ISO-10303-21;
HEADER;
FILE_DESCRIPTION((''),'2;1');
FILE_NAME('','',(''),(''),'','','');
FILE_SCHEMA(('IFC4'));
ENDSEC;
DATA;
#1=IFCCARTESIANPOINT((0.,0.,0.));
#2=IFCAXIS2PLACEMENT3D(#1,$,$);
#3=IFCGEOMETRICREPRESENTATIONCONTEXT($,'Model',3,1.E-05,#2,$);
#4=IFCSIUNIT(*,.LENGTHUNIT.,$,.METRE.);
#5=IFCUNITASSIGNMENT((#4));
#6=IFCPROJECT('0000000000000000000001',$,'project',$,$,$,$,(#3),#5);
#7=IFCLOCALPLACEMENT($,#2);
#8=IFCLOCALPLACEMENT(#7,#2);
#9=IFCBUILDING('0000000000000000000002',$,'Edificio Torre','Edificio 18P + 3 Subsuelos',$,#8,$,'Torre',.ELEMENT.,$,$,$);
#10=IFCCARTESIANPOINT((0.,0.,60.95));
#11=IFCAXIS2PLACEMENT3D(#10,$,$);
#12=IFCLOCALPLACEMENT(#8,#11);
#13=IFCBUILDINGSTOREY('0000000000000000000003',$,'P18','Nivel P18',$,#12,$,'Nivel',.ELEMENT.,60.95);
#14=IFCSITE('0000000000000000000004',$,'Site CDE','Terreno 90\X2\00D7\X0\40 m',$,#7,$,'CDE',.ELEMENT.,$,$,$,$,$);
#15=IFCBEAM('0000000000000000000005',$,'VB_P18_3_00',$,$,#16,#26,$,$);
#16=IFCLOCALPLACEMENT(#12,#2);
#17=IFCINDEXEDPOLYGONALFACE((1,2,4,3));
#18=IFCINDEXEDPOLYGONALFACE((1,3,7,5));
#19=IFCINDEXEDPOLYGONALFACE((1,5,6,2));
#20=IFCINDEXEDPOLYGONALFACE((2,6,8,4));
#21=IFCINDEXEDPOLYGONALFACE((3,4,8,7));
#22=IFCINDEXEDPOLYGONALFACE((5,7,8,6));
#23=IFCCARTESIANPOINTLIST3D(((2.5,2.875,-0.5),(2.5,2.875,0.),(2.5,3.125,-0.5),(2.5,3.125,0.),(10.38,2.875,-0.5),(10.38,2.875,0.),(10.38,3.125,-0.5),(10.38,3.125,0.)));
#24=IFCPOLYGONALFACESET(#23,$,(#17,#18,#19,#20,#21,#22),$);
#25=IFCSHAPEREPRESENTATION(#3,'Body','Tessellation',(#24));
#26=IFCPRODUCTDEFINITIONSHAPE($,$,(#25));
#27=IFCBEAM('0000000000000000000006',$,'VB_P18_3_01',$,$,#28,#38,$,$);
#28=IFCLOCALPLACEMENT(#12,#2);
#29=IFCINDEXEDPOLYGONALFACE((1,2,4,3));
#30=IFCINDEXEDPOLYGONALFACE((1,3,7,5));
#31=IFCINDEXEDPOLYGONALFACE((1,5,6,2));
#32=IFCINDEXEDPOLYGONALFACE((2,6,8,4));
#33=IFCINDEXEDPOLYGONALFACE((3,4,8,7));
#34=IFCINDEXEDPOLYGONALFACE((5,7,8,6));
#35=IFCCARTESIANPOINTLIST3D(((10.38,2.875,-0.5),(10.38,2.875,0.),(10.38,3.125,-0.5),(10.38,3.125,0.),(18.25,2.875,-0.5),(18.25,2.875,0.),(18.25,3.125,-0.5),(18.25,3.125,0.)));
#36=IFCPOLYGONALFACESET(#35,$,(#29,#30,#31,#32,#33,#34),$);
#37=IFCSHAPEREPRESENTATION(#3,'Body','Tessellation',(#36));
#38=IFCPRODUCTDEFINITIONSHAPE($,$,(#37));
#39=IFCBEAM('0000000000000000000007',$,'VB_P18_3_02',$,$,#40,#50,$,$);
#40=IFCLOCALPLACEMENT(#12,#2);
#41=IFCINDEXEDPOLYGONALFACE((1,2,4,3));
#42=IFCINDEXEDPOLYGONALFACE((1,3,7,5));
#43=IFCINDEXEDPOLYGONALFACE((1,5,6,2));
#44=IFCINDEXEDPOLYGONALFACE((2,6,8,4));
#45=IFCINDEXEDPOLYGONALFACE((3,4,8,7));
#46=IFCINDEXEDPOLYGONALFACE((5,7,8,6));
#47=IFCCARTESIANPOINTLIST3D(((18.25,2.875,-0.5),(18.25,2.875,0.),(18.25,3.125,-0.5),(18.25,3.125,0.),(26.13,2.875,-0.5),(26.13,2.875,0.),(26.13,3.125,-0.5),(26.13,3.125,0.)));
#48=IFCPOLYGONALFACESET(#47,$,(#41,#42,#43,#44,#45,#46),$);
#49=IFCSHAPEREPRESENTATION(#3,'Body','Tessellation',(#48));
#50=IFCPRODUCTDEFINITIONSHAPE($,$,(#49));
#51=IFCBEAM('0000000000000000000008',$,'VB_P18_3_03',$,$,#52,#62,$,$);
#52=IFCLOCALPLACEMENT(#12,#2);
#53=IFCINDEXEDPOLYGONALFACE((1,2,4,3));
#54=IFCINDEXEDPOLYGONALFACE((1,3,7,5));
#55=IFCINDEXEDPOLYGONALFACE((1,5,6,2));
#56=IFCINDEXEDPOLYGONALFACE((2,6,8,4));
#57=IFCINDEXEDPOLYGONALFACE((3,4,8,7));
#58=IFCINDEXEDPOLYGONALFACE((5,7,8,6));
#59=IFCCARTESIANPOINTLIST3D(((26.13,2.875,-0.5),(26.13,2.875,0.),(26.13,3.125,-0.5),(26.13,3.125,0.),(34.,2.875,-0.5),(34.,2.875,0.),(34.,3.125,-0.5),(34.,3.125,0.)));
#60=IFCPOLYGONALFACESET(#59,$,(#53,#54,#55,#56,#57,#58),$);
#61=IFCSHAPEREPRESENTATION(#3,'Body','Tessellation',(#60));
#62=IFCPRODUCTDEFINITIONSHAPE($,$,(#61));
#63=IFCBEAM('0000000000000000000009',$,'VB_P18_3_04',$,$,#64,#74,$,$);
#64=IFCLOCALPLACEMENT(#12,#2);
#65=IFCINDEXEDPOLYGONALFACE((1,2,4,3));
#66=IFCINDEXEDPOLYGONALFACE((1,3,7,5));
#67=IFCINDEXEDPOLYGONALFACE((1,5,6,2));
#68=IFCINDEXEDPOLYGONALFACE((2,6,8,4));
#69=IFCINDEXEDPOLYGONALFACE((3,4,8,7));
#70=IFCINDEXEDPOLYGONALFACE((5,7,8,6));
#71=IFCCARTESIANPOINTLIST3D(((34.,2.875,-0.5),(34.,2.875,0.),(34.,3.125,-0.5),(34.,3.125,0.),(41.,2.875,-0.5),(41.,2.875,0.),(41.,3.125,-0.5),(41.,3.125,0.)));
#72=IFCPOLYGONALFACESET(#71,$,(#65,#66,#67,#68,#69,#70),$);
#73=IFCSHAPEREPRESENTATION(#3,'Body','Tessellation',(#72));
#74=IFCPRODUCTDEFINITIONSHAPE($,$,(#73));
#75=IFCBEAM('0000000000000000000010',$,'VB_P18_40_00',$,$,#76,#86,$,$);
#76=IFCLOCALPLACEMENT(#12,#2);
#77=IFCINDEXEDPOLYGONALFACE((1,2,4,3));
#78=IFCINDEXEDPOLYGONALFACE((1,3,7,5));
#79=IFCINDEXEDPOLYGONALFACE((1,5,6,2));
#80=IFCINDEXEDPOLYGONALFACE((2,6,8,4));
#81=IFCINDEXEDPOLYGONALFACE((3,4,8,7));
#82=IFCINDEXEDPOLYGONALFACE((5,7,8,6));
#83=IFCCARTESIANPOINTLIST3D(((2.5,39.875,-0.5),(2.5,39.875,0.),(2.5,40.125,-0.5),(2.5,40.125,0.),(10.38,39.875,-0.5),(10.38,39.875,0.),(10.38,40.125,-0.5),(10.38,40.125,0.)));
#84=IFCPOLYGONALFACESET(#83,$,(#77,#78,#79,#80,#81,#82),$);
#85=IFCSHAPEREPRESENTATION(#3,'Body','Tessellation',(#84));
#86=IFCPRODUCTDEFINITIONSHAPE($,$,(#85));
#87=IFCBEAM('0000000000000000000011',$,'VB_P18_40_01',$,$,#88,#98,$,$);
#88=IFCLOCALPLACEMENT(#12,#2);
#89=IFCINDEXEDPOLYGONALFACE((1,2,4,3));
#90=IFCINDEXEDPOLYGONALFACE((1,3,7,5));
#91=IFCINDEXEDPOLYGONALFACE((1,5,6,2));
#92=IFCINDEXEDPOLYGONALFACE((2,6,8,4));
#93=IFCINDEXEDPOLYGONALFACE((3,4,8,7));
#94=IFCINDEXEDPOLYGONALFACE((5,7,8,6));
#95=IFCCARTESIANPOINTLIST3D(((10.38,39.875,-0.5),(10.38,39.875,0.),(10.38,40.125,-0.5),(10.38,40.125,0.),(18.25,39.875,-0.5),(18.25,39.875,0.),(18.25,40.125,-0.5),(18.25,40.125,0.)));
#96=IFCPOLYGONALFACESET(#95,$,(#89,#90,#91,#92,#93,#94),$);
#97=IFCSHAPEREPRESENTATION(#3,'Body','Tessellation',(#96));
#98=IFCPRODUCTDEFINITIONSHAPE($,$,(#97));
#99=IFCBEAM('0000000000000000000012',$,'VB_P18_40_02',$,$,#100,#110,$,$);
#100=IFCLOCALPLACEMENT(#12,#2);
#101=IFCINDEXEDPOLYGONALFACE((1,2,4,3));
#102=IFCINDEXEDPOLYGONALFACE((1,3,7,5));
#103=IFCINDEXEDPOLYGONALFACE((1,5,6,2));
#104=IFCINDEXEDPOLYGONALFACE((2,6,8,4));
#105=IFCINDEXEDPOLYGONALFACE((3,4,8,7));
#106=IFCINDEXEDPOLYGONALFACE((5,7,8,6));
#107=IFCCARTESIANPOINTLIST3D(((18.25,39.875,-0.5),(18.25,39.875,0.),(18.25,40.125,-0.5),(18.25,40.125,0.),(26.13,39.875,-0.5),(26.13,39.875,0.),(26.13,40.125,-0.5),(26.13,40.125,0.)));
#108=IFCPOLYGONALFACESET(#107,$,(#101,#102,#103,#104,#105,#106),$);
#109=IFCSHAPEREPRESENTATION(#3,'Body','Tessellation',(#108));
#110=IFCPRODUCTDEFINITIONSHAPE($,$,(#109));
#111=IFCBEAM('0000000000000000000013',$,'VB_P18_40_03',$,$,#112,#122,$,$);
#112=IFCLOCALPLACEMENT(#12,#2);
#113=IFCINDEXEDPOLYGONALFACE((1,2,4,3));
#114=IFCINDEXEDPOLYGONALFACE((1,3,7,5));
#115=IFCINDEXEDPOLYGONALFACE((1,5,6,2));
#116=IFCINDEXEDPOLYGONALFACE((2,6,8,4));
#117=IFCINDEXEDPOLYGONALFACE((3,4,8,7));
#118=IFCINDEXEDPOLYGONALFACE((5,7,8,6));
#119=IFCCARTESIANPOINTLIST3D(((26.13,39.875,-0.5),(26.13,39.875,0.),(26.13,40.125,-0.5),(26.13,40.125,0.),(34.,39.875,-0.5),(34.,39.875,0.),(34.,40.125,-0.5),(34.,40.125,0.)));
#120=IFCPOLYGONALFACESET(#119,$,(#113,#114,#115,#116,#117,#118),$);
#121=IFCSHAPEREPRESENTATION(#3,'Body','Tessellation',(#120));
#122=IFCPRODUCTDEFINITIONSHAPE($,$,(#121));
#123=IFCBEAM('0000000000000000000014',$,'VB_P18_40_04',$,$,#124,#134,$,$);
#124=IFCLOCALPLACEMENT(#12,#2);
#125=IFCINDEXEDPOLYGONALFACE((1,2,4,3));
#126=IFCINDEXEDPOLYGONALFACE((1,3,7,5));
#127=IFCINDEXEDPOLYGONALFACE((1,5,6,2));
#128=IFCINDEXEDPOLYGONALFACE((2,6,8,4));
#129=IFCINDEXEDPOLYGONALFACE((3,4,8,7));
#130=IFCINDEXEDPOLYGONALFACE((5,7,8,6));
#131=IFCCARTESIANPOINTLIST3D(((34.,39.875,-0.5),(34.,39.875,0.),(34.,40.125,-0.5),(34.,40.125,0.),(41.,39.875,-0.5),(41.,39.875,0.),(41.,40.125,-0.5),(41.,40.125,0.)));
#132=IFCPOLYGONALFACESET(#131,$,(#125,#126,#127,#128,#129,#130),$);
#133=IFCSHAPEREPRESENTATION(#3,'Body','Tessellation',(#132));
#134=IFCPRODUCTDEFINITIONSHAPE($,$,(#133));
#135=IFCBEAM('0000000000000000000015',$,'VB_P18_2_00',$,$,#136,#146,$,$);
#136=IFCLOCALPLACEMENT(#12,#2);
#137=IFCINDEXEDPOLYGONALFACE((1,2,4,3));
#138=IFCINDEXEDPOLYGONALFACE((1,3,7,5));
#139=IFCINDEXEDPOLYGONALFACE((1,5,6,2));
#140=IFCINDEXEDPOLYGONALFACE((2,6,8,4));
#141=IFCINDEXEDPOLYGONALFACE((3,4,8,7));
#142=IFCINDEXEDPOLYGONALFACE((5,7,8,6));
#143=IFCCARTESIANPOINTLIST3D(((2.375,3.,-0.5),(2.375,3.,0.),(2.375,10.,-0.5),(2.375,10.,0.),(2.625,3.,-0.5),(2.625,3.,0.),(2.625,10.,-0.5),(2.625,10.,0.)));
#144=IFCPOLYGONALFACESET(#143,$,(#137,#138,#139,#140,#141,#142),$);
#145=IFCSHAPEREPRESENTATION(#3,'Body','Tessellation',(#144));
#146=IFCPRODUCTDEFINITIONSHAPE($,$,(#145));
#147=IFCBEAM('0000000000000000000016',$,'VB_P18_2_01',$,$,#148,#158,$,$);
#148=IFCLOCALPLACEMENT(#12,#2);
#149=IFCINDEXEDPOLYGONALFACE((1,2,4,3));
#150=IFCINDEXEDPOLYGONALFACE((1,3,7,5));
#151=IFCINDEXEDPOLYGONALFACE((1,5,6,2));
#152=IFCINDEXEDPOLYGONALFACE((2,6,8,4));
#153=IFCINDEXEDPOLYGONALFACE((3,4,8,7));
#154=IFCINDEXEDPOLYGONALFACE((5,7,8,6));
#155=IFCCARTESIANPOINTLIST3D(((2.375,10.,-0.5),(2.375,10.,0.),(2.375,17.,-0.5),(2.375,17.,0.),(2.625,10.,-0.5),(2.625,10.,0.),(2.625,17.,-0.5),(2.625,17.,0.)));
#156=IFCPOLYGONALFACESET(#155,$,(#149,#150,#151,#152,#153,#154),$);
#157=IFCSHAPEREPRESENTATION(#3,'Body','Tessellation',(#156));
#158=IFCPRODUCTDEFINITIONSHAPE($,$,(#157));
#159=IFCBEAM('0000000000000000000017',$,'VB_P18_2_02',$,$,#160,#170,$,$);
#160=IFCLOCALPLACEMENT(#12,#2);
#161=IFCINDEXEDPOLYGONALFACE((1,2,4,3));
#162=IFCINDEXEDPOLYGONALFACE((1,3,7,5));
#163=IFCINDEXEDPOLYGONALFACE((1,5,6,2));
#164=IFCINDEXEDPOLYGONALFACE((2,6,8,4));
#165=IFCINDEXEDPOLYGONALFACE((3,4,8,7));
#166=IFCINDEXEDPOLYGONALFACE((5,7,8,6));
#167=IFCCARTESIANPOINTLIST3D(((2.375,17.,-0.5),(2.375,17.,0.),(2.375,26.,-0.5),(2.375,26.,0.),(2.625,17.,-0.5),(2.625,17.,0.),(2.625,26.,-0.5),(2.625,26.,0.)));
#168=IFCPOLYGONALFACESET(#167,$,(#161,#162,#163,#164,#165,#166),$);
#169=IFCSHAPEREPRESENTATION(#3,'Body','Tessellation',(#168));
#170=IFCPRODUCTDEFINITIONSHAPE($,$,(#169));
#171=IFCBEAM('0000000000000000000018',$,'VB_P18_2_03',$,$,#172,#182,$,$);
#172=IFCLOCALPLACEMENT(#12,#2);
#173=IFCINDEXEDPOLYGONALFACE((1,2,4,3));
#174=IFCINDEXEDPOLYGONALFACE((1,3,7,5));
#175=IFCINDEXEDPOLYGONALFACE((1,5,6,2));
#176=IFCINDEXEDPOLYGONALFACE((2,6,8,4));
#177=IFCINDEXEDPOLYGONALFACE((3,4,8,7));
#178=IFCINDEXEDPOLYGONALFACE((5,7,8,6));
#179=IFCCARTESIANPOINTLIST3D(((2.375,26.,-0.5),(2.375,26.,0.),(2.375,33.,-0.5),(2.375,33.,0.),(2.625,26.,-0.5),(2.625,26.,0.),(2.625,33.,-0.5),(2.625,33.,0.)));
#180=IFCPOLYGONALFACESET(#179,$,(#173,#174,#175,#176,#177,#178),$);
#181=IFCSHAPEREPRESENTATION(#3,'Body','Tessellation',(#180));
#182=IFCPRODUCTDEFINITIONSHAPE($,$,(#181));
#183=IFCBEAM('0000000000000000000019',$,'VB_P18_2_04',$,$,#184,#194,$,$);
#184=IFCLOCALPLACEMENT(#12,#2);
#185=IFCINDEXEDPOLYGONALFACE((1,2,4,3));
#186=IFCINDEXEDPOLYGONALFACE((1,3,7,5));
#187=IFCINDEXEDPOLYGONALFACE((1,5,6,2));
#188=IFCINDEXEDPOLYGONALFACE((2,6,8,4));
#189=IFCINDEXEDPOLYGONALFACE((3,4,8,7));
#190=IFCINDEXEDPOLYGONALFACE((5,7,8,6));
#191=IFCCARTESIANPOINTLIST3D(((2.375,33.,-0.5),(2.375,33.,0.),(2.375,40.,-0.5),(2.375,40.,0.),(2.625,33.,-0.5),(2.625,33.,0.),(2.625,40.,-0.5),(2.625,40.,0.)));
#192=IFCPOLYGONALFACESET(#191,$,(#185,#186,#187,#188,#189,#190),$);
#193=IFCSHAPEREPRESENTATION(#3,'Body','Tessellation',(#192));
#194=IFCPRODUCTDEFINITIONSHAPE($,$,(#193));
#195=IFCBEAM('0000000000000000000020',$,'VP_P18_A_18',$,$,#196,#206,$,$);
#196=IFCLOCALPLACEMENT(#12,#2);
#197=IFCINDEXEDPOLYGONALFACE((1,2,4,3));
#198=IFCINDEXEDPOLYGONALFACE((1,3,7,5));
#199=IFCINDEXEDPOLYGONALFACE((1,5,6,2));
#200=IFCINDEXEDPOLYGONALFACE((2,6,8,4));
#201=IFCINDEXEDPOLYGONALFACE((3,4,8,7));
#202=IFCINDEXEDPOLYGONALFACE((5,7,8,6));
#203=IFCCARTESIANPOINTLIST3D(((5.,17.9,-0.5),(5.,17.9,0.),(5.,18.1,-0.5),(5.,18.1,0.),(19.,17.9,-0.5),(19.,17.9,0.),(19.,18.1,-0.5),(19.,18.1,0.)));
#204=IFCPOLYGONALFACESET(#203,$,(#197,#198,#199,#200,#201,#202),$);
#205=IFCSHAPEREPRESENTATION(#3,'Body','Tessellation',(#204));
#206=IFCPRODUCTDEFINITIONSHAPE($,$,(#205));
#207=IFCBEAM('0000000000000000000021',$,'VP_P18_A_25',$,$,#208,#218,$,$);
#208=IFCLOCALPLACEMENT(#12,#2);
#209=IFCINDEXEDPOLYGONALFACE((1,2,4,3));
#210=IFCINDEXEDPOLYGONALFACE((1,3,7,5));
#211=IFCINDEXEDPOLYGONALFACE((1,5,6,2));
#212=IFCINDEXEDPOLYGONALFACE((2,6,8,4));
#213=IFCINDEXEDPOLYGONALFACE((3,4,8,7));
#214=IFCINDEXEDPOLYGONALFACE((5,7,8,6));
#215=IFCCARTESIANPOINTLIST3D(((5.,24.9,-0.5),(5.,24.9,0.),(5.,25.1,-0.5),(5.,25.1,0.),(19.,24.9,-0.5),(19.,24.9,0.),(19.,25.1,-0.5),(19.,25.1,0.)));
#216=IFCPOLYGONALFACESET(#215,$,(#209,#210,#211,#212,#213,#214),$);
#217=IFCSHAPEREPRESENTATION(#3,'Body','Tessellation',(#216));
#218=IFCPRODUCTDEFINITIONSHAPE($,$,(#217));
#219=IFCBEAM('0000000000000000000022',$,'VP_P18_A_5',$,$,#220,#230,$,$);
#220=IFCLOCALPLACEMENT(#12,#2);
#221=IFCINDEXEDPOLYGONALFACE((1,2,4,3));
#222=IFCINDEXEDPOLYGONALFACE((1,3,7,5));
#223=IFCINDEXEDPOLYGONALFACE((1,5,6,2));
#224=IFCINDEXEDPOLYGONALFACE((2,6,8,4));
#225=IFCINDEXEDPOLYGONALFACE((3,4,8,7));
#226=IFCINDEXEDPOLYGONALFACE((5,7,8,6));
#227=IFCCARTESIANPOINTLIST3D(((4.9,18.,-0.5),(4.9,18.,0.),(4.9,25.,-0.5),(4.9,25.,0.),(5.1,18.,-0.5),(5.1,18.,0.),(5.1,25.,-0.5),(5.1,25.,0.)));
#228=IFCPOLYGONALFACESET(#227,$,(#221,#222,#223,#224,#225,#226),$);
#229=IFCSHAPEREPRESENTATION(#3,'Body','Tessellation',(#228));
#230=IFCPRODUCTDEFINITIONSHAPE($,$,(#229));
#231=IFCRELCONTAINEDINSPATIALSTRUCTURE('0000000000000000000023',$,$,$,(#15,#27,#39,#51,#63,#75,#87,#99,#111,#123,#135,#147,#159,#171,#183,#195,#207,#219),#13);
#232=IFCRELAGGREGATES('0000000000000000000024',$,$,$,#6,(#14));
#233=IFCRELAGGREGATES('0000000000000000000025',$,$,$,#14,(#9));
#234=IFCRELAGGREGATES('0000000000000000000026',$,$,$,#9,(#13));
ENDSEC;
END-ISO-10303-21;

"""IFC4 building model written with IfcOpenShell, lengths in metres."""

from ifc_helpers import new_model, si_unit, frame, origin, origin_2d, place, context, project, spatial, rectangle, extrude, element, save


model = new_model("IFC4")

# Units and contexts
model_context = context("Model", 3, precision=1e-05, world=origin())
ifc_project = project(units=[si_unit("LENGTHUNIT", "METRE")], contexts=[model_context])

# Site, building, storey
site_placement = place(None, origin())
site = spatial("IfcSite", under=ifc_project, at=site_placement, Name="Site CDE", Description="Terreno 90×40 m", LongName="CDE", CompositionType="ELEMENT")
building_placement = place(site_placement, origin())
building = spatial("IfcBuilding", under=site, at=building_placement, Name="Edificio Torre", Description="Edificio 18P + 3 Subsuelos", LongName="Torre", CompositionType="ELEMENT")
storey_placement = place(building_placement, frame((0.0, 0.0, 60.95)))
storey = spatial("IfcBuildingStorey", under=building, at=storey_placement, Name="P18", Description="Nivel P18", LongName="Nivel", CompositionType="ELEMENT", Elevation=60.95)

# Beams
beam_1_placement = place(storey_placement, frame((6.44, 3.0, -0.5)))
element("IfcBeam", 1, at=beam_1_placement, inside=storey, Name="VB_P18_3_00", context=model_context, shape_type="SweptSolid", body=[
    extrude(rectangle(XDim=7.88, YDim=0.25, at=origin_2d()), origin(), (0.0, 0.0, 1.0), 0.5),
])
beam_2_placement = place(storey_placement, frame((14.315, 3.0, -0.5)))
element("IfcBeam", 2, at=beam_2_placement, inside=storey, Name="VB_P18_3_01", context=model_context, shape_type="SweptSolid", body=[
    extrude(rectangle(XDim=7.87, YDim=0.25, at=origin_2d()), origin(), (0.0, 0.0, 1.0), 0.5),
])
beam_3_placement = place(storey_placement, frame((22.19, 3.0, -0.5)))
element("IfcBeam", 3, at=beam_3_placement, inside=storey, Name="VB_P18_3_02", context=model_context, shape_type="SweptSolid", body=[
    extrude(rectangle(XDim=7.88, YDim=0.25, at=origin_2d()), origin(), (0.0, 0.0, 1.0), 0.5),
])
beam_4_placement = place(storey_placement, frame((30.065, 3.0, -0.5)))
element("IfcBeam", 4, at=beam_4_placement, inside=storey, Name="VB_P18_3_03", context=model_context, shape_type="SweptSolid", body=[
    extrude(rectangle(XDim=7.87, YDim=0.25, at=origin_2d()), origin(), (0.0, 0.0, 1.0), 0.5),
])
beam_5_placement = place(storey_placement, frame((37.5, 3.0, -0.5)))
element("IfcBeam", 5, at=beam_5_placement, inside=storey, Name="VB_P18_3_04", context=model_context, shape_type="SweptSolid", body=[
    extrude(rectangle(XDim=7.0, YDim=0.25, at=origin_2d()), origin(), (0.0, 0.0, 1.0), 0.5),
])
beam_6_placement = place(storey_placement, frame((6.44, 40.0, -0.5)))
element("IfcBeam", 6, at=beam_6_placement, inside=storey, Name="VB_P18_40_00", context=model_context, shape_type="SweptSolid", body=[
    extrude(rectangle(XDim=7.88, YDim=0.25, at=origin_2d()), origin(), (0.0, 0.0, 1.0), 0.5),
])
beam_7_placement = place(storey_placement, frame((14.315, 40.0, -0.5)))
element("IfcBeam", 7, at=beam_7_placement, inside=storey, Name="VB_P18_40_01", context=model_context, shape_type="SweptSolid", body=[
    extrude(rectangle(XDim=7.87, YDim=0.25, at=origin_2d()), origin(), (0.0, 0.0, 1.0), 0.5),
])
beam_8_placement = place(storey_placement, frame((22.19, 40.0, -0.5)))
element("IfcBeam", 8, at=beam_8_placement, inside=storey, Name="VB_P18_40_02", context=model_context, shape_type="SweptSolid", body=[
    extrude(rectangle(XDim=7.88, YDim=0.25, at=origin_2d()), origin(), (0.0, 0.0, 1.0), 0.5),
])
beam_9_placement = place(storey_placement, frame((30.065, 40.0, -0.5)))
element("IfcBeam", 9, at=beam_9_placement, inside=storey, Name="VB_P18_40_03", context=model_context, shape_type="SweptSolid", body=[
    extrude(rectangle(XDim=7.87, YDim=0.25, at=origin_2d()), origin(), (0.0, 0.0, 1.0), 0.5),
])
beam_10_placement = place(storey_placement, frame((37.5, 40.0, -0.5)))
element("IfcBeam", 10, at=beam_10_placement, inside=storey, Name="VB_P18_40_04", context=model_context, shape_type="SweptSolid", body=[
    extrude(rectangle(XDim=7.0, YDim=0.25, at=origin_2d()), origin(), (0.0, 0.0, 1.0), 0.5),
])
for number, where, name in (
    (11, (2.5, 6.5, -0.5), "VB_P18_2_00"),
    (12, (2.5, 13.5, -0.5), "VB_P18_2_01"),
):
    element("IfcBeam", number, at=place(storey_placement, frame(where)), inside=storey, Name=name, context=model_context, shape_type="SweptSolid", body=[
        extrude(rectangle(XDim=0.25, YDim=7.0, at=origin_2d()), origin(), (0.0, 0.0, 1.0), 0.5),
    ])
beam_11_placement = place(storey_placement, frame((2.5, 21.5, -0.5)))
element("IfcBeam", 13, at=beam_11_placement, inside=storey, Name="VB_P18_2_02", context=model_context, shape_type="SweptSolid", body=[
    extrude(rectangle(XDim=0.25, YDim=9.0, at=origin_2d()), origin(), (0.0, 0.0, 1.0), 0.5),
])
for number, where, name in (
    (14, (2.5, 29.5, -0.5), "VB_P18_2_03"),
    (15, (2.5, 36.5, -0.5), "VB_P18_2_04"),
):
    element("IfcBeam", number, at=place(storey_placement, frame(where)), inside=storey, Name=name, context=model_context, shape_type="SweptSolid", body=[
        extrude(rectangle(XDim=0.25, YDim=7.0, at=origin_2d()), origin(), (0.0, 0.0, 1.0), 0.5),
    ])
for number, where, name in (
    (16, (12.0, 18.0, -0.5), "VP_P18_A_18"),
    (17, (12.0, 25.0, -0.5), "VP_P18_A_25"),
):
    element("IfcBeam", number, at=place(storey_placement, frame(where)), inside=storey, Name=name, context=model_context, shape_type="SweptSolid", body=[
        extrude(rectangle(XDim=14.0, YDim=0.2, at=origin_2d()), origin(), (0.0, 0.0, 1.0), 0.5),
    ])
beam_12_placement = place(storey_placement, frame((5.0, 21.5, -0.5)))
element("IfcBeam", 18, at=beam_12_placement, inside=storey, Name="VP_P18_A_5", context=model_context, shape_type="SweptSolid", body=[
    extrude(rectangle(XDim=0.2, YDim=7.0, at=origin_2d()), origin(), (0.0, 0.0, 1.0), 0.5),
])

save(model, "model.ifc")
